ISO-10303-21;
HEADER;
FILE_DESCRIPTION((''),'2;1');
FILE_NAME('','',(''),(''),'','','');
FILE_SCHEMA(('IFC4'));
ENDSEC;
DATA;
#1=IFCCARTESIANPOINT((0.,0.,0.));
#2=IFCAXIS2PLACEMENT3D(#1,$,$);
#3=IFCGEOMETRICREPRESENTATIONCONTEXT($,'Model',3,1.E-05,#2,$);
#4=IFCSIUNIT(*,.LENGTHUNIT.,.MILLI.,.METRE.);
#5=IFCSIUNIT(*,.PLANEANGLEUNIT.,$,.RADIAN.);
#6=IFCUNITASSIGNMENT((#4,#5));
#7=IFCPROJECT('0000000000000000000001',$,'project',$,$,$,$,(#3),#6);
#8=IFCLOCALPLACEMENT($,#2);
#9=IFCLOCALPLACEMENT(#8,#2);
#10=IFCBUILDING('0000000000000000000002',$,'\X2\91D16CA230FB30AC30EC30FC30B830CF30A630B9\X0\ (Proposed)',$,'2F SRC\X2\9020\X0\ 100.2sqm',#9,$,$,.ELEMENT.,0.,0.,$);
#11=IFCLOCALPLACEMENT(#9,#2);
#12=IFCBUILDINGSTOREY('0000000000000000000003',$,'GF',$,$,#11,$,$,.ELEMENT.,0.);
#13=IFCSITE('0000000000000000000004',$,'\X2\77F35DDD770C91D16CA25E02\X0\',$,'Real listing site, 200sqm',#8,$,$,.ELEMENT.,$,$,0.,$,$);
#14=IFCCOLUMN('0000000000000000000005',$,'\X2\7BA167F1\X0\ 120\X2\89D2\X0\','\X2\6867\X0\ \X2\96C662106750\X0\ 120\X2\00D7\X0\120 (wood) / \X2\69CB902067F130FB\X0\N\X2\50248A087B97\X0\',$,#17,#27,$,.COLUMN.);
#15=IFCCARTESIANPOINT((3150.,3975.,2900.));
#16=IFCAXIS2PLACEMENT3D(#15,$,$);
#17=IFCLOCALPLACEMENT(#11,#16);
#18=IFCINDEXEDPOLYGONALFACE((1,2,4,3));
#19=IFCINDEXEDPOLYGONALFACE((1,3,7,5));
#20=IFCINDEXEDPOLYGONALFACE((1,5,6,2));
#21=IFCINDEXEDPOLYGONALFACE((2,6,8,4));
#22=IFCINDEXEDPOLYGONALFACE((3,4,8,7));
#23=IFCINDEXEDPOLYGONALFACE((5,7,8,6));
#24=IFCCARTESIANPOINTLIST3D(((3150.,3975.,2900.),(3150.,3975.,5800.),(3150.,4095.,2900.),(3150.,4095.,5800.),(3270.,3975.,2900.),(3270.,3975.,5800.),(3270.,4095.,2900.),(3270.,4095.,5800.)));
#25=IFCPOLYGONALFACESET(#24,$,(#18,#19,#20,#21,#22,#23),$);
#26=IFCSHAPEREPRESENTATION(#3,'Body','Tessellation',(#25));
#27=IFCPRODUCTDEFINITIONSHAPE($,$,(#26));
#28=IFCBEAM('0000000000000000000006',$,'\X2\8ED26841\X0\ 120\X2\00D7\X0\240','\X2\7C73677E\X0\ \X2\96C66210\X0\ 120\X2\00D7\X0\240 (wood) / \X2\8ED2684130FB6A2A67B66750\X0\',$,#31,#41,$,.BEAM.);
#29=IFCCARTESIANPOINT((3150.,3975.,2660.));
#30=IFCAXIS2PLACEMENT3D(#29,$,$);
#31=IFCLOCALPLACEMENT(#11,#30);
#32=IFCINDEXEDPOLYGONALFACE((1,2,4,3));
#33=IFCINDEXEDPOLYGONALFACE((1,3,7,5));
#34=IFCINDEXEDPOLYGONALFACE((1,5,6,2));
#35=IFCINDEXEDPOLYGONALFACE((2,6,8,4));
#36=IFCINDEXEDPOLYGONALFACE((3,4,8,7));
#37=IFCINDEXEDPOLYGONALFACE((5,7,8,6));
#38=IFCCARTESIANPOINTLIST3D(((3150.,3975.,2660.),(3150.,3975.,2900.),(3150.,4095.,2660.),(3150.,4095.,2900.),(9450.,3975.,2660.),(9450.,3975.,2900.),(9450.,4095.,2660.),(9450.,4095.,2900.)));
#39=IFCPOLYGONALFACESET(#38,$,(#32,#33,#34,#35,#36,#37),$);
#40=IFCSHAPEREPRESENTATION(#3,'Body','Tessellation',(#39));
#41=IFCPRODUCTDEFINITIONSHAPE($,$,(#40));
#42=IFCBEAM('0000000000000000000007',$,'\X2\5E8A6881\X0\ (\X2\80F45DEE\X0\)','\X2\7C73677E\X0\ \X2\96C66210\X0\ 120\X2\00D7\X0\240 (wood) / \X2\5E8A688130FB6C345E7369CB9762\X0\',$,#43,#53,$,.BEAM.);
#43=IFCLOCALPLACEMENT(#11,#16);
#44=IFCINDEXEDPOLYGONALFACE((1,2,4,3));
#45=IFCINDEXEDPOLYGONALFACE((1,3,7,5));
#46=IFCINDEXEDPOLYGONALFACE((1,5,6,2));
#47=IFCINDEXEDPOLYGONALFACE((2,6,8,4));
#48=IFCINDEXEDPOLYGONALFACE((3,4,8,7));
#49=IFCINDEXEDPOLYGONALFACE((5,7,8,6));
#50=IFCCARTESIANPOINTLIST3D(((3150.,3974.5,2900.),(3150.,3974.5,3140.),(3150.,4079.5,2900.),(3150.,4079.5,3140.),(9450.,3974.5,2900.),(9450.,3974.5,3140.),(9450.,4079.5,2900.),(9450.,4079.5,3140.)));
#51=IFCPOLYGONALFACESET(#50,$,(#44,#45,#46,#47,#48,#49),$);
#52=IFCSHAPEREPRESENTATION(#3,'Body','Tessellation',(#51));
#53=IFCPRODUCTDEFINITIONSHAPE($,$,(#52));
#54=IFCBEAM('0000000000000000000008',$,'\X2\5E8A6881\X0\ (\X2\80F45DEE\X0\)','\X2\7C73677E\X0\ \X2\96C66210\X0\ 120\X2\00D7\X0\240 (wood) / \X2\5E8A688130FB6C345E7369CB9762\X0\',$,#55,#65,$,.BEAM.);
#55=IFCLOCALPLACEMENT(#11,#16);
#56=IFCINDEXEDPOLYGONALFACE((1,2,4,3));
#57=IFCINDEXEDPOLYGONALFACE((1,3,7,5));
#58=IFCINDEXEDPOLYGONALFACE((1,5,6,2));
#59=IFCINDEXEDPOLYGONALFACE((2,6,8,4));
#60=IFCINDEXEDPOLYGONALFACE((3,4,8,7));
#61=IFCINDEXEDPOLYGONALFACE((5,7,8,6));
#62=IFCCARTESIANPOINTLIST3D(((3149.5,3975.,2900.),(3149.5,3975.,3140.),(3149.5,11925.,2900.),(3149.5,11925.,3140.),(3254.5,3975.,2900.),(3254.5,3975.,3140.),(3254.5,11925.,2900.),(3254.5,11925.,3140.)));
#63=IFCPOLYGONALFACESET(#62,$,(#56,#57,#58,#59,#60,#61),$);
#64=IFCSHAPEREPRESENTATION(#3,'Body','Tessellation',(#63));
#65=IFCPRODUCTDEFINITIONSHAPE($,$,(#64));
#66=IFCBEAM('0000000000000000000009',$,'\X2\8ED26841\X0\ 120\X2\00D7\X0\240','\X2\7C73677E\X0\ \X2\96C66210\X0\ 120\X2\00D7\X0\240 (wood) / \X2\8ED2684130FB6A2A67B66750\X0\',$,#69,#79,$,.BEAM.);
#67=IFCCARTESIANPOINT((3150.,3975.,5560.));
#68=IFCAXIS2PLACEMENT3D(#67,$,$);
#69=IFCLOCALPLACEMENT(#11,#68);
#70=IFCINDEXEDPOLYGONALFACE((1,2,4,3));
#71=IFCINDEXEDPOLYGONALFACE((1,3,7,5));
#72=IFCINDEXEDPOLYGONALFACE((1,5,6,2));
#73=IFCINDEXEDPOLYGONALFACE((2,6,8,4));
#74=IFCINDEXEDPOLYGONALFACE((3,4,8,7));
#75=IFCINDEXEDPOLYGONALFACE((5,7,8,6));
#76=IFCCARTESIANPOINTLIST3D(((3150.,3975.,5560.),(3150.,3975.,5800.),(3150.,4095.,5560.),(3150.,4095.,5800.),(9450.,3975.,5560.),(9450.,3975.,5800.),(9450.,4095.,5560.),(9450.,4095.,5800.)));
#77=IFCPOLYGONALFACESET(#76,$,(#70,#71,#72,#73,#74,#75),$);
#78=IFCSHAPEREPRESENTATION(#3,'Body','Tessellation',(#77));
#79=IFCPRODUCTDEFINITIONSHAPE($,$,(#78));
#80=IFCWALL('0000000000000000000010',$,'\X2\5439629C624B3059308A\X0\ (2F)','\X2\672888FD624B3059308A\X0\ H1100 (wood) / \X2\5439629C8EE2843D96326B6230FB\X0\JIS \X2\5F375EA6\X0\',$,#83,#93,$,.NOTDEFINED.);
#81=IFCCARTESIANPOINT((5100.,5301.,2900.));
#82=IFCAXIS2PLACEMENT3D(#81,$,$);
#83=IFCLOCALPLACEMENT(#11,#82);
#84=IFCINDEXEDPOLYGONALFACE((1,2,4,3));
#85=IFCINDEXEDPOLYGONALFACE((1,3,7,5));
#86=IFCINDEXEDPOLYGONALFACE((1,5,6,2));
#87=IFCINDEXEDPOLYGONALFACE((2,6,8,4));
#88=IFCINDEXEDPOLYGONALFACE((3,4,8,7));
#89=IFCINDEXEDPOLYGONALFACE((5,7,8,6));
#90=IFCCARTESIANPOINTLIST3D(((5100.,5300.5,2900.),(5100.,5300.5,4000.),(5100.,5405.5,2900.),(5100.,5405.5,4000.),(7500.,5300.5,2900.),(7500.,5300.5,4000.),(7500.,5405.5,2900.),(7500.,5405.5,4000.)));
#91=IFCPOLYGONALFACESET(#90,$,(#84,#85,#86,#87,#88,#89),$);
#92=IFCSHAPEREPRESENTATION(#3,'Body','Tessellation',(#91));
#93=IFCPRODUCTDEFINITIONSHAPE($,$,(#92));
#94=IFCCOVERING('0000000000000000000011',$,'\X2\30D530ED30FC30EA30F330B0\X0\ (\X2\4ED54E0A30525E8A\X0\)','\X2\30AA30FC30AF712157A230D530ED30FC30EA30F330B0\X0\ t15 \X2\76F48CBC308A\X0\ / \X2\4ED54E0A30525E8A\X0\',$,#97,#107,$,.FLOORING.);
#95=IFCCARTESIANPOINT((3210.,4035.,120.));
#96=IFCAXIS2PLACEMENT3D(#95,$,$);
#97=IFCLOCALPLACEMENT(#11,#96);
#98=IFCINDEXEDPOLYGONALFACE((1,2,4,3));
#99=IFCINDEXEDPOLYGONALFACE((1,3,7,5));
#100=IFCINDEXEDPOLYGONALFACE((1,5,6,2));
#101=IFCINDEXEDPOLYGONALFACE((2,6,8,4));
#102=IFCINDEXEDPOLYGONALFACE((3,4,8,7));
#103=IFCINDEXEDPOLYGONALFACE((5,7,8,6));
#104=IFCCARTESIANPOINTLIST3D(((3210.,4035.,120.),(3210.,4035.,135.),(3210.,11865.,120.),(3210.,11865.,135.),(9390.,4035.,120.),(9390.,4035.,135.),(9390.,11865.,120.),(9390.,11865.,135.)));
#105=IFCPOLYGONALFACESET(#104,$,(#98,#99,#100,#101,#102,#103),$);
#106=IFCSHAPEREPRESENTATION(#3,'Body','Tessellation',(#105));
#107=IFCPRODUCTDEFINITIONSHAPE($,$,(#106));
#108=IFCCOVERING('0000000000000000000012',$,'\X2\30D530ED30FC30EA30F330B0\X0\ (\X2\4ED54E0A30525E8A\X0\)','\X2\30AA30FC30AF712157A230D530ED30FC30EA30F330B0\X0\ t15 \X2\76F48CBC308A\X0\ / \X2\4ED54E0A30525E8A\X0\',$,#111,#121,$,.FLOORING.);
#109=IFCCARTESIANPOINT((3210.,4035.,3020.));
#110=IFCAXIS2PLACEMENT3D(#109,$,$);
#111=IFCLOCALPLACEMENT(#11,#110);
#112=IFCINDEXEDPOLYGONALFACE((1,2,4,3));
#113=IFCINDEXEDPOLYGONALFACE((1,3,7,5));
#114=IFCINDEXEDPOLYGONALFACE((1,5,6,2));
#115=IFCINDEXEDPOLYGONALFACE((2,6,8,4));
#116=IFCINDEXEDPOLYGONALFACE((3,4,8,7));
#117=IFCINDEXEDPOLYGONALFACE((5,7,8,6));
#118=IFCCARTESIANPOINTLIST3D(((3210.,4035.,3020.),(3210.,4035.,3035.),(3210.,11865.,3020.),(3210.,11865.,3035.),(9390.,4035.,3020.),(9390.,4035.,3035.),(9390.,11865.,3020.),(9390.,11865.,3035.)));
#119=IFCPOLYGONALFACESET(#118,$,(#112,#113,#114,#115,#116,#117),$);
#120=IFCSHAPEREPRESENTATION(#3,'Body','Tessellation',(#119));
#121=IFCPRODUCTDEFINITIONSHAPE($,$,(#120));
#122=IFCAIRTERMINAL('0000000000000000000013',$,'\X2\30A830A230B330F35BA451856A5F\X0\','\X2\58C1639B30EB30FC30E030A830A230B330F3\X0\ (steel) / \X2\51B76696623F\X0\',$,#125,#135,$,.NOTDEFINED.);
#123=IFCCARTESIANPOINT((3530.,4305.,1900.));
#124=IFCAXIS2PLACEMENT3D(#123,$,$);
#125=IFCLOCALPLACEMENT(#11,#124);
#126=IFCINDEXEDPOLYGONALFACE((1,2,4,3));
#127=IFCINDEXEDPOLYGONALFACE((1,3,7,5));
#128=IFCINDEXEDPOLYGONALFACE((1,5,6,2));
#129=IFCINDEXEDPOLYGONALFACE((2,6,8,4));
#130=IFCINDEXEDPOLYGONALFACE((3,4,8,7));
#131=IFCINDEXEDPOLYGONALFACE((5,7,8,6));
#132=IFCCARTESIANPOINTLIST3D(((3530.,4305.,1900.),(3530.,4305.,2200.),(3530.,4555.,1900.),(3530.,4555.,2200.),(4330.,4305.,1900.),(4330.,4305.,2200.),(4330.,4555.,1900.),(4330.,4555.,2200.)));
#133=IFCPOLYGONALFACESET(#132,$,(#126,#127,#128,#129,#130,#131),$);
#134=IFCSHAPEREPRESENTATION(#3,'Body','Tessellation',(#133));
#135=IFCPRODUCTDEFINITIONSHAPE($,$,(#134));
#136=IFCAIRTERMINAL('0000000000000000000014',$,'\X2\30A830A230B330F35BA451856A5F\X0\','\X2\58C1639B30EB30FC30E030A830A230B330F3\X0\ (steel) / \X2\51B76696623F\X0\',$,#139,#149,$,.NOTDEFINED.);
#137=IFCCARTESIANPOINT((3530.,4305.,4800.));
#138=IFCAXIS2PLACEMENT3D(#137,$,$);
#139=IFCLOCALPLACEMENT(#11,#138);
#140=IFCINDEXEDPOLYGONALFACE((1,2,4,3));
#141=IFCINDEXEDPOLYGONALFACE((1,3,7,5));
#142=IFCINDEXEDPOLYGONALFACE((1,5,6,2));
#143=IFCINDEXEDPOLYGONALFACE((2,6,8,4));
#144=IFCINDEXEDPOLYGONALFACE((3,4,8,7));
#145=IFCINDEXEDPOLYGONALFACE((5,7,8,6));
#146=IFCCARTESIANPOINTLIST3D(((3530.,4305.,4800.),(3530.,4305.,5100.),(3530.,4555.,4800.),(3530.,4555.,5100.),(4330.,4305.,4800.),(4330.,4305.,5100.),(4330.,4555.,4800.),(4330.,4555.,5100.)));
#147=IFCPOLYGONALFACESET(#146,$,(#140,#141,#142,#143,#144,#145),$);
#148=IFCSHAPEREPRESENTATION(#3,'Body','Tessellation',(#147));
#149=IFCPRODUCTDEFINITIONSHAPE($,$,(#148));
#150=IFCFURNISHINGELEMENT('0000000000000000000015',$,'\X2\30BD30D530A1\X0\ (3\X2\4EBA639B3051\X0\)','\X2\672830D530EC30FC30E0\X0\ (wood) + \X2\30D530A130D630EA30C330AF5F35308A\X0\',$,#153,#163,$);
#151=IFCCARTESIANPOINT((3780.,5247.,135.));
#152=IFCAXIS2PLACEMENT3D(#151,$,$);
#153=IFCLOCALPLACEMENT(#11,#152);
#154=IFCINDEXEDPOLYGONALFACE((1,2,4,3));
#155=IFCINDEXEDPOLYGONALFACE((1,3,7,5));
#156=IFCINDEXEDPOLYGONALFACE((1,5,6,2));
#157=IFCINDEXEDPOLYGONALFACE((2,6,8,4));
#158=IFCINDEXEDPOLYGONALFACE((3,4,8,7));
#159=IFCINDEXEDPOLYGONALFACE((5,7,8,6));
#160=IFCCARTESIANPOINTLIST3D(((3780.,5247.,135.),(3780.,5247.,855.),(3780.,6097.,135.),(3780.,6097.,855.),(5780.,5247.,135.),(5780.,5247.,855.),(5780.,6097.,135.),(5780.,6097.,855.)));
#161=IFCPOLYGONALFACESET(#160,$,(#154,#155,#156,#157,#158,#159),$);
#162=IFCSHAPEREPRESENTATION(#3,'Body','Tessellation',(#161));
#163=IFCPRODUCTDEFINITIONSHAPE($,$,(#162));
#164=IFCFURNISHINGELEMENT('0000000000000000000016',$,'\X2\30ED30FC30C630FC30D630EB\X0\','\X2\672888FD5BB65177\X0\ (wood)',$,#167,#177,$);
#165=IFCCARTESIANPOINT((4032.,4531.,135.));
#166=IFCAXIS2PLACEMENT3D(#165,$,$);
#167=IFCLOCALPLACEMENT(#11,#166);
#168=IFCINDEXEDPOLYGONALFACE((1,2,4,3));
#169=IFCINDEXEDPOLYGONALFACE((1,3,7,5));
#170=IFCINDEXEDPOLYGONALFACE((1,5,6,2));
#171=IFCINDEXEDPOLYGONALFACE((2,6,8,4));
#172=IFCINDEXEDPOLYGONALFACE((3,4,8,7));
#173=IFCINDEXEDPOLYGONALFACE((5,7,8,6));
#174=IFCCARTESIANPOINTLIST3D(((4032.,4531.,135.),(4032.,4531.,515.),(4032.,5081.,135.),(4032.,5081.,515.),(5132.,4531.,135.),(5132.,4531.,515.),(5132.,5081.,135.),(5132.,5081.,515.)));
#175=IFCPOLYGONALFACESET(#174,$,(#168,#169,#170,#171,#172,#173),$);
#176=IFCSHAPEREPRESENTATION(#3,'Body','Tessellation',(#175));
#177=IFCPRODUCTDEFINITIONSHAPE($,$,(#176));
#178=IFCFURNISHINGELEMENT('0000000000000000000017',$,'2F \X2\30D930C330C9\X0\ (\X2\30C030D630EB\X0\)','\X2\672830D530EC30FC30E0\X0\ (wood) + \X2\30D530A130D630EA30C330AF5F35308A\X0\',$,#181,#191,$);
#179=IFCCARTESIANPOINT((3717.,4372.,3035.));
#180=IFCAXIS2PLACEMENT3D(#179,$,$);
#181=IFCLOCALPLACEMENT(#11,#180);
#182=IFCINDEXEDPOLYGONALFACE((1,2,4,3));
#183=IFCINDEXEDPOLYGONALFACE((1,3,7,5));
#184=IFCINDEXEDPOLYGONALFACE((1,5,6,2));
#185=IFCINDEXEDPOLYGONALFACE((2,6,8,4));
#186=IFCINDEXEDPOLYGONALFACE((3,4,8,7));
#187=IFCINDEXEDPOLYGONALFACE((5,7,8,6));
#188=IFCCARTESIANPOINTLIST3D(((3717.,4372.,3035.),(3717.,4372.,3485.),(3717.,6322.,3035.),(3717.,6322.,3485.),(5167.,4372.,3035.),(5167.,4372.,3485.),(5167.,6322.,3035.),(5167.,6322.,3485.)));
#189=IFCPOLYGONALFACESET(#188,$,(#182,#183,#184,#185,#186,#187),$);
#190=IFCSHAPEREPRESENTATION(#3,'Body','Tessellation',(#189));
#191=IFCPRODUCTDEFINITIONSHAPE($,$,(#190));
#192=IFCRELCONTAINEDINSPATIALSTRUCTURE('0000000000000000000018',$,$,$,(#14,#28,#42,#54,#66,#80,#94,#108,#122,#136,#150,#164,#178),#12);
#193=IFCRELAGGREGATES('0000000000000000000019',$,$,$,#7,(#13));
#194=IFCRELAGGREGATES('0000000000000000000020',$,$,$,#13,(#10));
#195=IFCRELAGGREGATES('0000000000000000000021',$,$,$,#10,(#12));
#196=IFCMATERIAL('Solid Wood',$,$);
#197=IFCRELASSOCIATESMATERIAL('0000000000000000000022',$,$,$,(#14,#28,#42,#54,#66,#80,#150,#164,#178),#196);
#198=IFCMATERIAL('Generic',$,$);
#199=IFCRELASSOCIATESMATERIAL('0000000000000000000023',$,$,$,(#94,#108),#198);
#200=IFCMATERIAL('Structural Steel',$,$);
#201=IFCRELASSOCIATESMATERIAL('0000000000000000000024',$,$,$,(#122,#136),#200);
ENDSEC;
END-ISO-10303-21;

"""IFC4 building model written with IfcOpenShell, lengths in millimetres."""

from ifc_helpers import new_model, si_unit, frame, frame_2d, origin, place, context, project, spatial, rectangle, extrude, material, element, save


model = new_model("IFC4")

# Units and contexts
model_context = context("Model", 3, precision=1e-05, world=origin())
ifc_project = project(units=[si_unit("LENGTHUNIT", "METRE", prefix="MILLI"), si_unit("PLANEANGLEUNIT", "RADIAN")], contexts=[model_context])

# Site, building, storey
site_placement = place(None, origin())
site = spatial("IfcSite", under=ifc_project, at=site_placement, Name="石川県金沢市", ObjectType="Real listing site, 200sqm", CompositionType="ELEMENT", RefElevation=0.0)
building_placement = place(site_placement, origin())
building = spatial("IfcBuilding", under=site, at=building_placement, Name="金沢・ガレージハウス (Proposed)", ObjectType="2F SRC造 100.2sqm", CompositionType="ELEMENT", ElevationOfRefHeight=0.0, ElevationOfTerrain=0.0)
storey_placement = place(building_placement, origin())
storey = spatial("IfcBuildingStorey", under=building, at=storey_placement, Name="GF", CompositionType="ELEMENT", Elevation=0.0)

# Column
ifc_material_1 = material(Name="Solid Wood")
column_placement = place(storey_placement, frame((3150.0, 3975.0, 2900.0)))
element("IfcColumn", 1, at=column_placement, inside=storey, material=ifc_material_1, Name="管柱 120角", Description="桧 集成材 120×120 (wood) / 構造柱・N値計算", PredefinedType="COLUMN", context=model_context, shape_type="SweptSolid", body=[
    extrude(rectangle(XDim=120.0, YDim=120.0, at=frame_2d((60.0, 60.0))), frame((3150.0, 3975.0, 2900.0)), (0.0, 0.0, 1.0), 2900.0),
])

# Beams
beam_1_placement = place(storey_placement, frame((3150.0, 3975.0, 2660.0)))
element("IfcBeam", 2, at=beam_1_placement, inside=storey, material=ifc_material_1, Name="軒桁 120×240", Description="米松 集成 120×240 (wood) / 軒桁・横架材", PredefinedType="BEAM", context=model_context, shape_type="SweptSolid", body=[
    extrude(rectangle(XDim=6300.0, YDim=120.0, at=frame_2d((3150.0, 60.0))), frame((3150.0, 3975.0, 2660.0)), (0.0, 0.0, 1.0), 240.0),
])
beam_2_placement = place(storey_placement, frame((3150.0, 3975.0, 2900.0)))
element("IfcBeam", 3, at=beam_2_placement, inside=storey, material=ifc_material_1, Name="床梁 (胴差)", Description="米松 集成 120×240 (wood) / 床梁・水平構面", PredefinedType="BEAM", context=model_context, shape_type="SweptSolid", body=[
    extrude(rectangle(XDim=6300.0, YDim=105.0, at=frame_2d((3150.0, 52.0))), frame((3150.0, 3975.0, 2900.0)), (0.0, 0.0, 1.0), 240.0),
])
beam_3_placement = place(storey_placement, frame((3150.0, 3975.0, 2900.0)))
element("IfcBeam", 4, at=beam_3_placement, inside=storey, material=ifc_material_1, Name="床梁 (胴差)", Description="米松 集成 120×240 (wood) / 床梁・水平構面", PredefinedType="BEAM", context=model_context, shape_type="SweptSolid", body=[
    extrude(rectangle(XDim=105.0, YDim=7950.0, at=frame_2d((52.0, 3975.0))), frame((3150.0, 3975.0, 2900.0)), (0.0, 0.0, 1.0), 240.0),
])
beam_4_placement = place(storey_placement, frame((3150.0, 3975.0, 5560.0)))
element("IfcBeam", 5, at=beam_4_placement, inside=storey, material=ifc_material_1, Name="軒桁 120×240", Description="米松 集成 120×240 (wood) / 軒桁・横架材", PredefinedType="BEAM", context=model_context, shape_type="SweptSolid", body=[
    extrude(rectangle(XDim=6300.0, YDim=120.0, at=frame_2d((3150.0, 60.0))), frame((3150.0, 3975.0, 5560.0)), (0.0, 0.0, 1.0), 240.0),
])

# Wall
wall_placement = place(storey_placement, frame((5100.0, 5301.0, 2900.0)))
element("IfcWall", 6, at=wall_placement, inside=storey, material=ifc_material_1, Name="吹抜手すり (2F)", Description="木製手すり H1100 (wood) / 吹抜転落防止・JIS 強度", PredefinedType="NOTDEFINED", context=model_context, shape_type="SweptSolid", body=[
    extrude(rectangle(XDim=2400.0, YDim=105.0, at=frame_2d((1200.0, 52.0))), frame((5100.0, 5301.0, 2900.0)), (0.0, 0.0, 1.0), 1100.0),
])

# Coverings
ifc_material_2 = material(Name="Generic")
covering_1_placement = place(storey_placement, frame((3210.0, 4035.0, 120.0)))
element("IfcCovering", 7, at=covering_1_placement, inside=storey, material=ifc_material_2, Name="フローリング (仕上げ床)", Description="オーク無垢フローリング t15 直貼り / 仕上げ床", PredefinedType="FLOORING", context=model_context, shape_type="SweptSolid", body=[
    extrude(rectangle(XDim=6180.0, YDim=7830.0, at=frame_2d((3090.0, 3915.0))), frame((3210.0, 4035.0, 120.0)), (0.0, 0.0, 1.0), 15.0),
])
covering_2_placement = place(storey_placement, frame((3210.0, 4035.0, 3020.0)))
element("IfcCovering", 8, at=covering_2_placement, inside=storey, material=ifc_material_2, Name="フローリング (仕上げ床)", Description="オーク無垢フローリング t15 直貼り / 仕上げ床", PredefinedType="FLOORING", context=model_context, shape_type="SweptSolid", body=[
    extrude(rectangle(XDim=6180.0, YDim=7830.0, at=frame_2d((3090.0, 3915.0))), frame((3210.0, 4035.0, 3020.0)), (0.0, 0.0, 1.0), 15.0),
])

# Air terminals
ifc_material_3 = material(Name="Structural Steel")
air_terminal_1_placement = place(storey_placement, frame((3530.0, 4305.0, 1900.0)))
element("IfcAirTerminal", 9, at=air_terminal_1_placement, inside=storey, material=ifc_material_3, Name="エアコン室内機", Description="壁掛ルームエアコン (steel) / 冷暖房", PredefinedType="NOTDEFINED", context=model_context, shape_type="SweptSolid", body=[
    extrude(rectangle(XDim=800.0, YDim=250.0, at=frame_2d((400.0, 125.0))), frame((3530.0, 4305.0, 1900.0)), (0.0, 0.0, 1.0), 300.0),
])
air_terminal_2_placement = place(storey_placement, frame((3530.0, 4305.0, 4800.0)))
element("IfcAirTerminal", 10, at=air_terminal_2_placement, inside=storey, material=ifc_material_3, Name="エアコン室内機", Description="壁掛ルームエアコン (steel) / 冷暖房", PredefinedType="NOTDEFINED", context=model_context, shape_type="SweptSolid", body=[
    extrude(rectangle(XDim=800.0, YDim=250.0, at=frame_2d((400.0, 125.0))), frame((3530.0, 4305.0, 4800.0)), (0.0, 0.0, 1.0), 300.0),
])

# Furnishing elements
furnishing_1_placement = place(storey_placement, frame((3780.0, 5247.0, 135.0)))
element("IfcFurnishingElement", 11, at=furnishing_1_placement, inside=storey, material=ifc_material_1, Name="ソファ (3人掛け)", Description="木フレーム (wood) + ファブリック張り", context=model_context, shape_type="SweptSolid", body=[
    extrude(rectangle(XDim=2000.0, YDim=850.0, at=frame_2d((1000.0, 425.0))), frame((3780.0, 5247.0, 135.0)), (0.0, 0.0, 1.0), 720.0),
])
furnishing_2_placement = place(storey_placement, frame((4032.0, 4531.0, 135.0)))
element("IfcFurnishingElement", 12, at=furnishing_2_placement, inside=storey, material=ifc_material_1, Name="ローテーブル", Description="木製家具 (wood)", context=model_context, shape_type="SweptSolid", body=[
    extrude(rectangle(XDim=1100.0, YDim=550.0, at=frame_2d((550.0, 275.0))), frame((4032.0, 4531.0, 135.0)), (0.0, 0.0, 1.0), 380.0),
])
furnishing_3_placement = place(storey_placement, frame((3717.0, 4372.0, 3035.0)))
element("IfcFurnishingElement", 13, at=furnishing_3_placement, inside=storey, material=ifc_material_1, Name="2F ベッド (ダブル)", Description="木フレーム (wood) + ファブリック張り", context=model_context, shape_type="SweptSolid", body=[
    extrude(rectangle(XDim=1450.0, YDim=1950.0, at=frame_2d((725.0, 975.0))), frame((3717.0, 4372.0, 3035.0)), (0.0, 0.0, 1.0), 450.0),
])

save(model, "model.ifc")
